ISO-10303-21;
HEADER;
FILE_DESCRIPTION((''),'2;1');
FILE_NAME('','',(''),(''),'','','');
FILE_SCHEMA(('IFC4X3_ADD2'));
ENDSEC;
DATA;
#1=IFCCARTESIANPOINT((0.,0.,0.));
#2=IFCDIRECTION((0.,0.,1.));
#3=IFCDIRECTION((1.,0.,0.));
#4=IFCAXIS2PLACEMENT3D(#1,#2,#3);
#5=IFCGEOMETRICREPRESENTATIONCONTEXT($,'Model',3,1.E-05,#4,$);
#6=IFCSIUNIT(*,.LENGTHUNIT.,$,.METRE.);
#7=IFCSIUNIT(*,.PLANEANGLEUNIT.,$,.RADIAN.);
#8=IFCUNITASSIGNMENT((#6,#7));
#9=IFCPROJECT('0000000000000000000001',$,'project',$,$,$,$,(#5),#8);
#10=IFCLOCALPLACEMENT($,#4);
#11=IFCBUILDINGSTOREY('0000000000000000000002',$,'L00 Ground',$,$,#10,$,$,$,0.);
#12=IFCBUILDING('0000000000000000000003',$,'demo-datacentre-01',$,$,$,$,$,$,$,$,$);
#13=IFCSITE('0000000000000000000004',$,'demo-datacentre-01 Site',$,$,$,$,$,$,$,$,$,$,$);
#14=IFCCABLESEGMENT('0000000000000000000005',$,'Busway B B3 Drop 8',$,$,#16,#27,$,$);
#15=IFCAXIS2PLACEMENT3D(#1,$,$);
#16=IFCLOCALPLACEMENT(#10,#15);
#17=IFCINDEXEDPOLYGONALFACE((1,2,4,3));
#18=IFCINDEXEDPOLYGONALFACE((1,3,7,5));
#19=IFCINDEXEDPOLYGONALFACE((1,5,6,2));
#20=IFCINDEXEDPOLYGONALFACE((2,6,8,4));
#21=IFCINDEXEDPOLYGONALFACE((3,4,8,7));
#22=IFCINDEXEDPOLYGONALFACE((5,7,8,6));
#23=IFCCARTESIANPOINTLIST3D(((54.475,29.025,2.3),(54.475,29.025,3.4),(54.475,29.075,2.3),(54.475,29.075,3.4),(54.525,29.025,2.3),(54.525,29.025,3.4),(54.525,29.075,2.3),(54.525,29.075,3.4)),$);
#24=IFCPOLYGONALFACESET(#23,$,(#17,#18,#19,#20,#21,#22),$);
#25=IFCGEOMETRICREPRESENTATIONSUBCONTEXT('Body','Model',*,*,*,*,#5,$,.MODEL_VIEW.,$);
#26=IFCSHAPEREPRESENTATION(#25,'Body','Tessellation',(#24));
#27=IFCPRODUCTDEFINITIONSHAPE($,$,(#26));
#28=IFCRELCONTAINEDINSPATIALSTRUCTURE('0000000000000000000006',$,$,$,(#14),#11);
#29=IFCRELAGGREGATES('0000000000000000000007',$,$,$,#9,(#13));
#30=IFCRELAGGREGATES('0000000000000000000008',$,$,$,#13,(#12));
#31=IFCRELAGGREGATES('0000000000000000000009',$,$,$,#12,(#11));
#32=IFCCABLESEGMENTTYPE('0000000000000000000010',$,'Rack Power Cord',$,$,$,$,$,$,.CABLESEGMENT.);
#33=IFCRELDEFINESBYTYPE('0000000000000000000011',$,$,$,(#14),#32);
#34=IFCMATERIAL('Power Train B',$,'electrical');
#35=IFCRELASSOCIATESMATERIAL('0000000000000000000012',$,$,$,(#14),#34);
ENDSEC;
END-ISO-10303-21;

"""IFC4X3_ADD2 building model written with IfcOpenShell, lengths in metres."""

from ifc_helpers import new_model, si_unit, frame, origin_with_axes, place, context, subcontext, project, spatial, rectangle, extrude, material, type_object, element, save


model = new_model("IFC4X3_ADD2")

# Units and contexts
model_context = context("Model", 3, precision=1e-05, world=origin_with_axes())
body_context = subcontext(model_context, "Body", "Model", "MODEL_VIEW")
ifc_project = project(units=[si_unit("LENGTHUNIT", "METRE"), si_unit("PLANEANGLEUNIT", "RADIAN")], contexts=[model_context])

# Site, building, storey
site = spatial("IfcSite", under=ifc_project, Name="demo-datacentre-01 Site")
building = spatial("IfcBuilding", under=site, Name="demo-datacentre-01")
storey_placement = place(None, origin_with_axes())
storey = spatial("IfcBuildingStorey", under=building, at=storey_placement, Name="L00 Ground", Elevation=0.0)

# Shared definitions
ifc_material_1 = material(Name="Power Train B", Category="electrical")

# Cable segment
cable_segment_type_1 = type_object("IfcCableSegmentType", Name="Rack Power Cord", PredefinedType="CABLESEGMENT")
for number, where, z_axis, x_axis, name in (
    (1, (54.5, 29.05, 3.4), (0.0, 0.0, -1.0), (1.0, 0.0, 0.0), "Busway B B3 Drop 8"),
):
    element("IfcCableSegment", number, at=place(storey_placement, frame(where, z_axis=z_axis, x_axis=x_axis)), inside=storey, type_object=cable_segment_type_1, material=ifc_material_1, Name=name, context=body_context, shape_type="SweptSolid", body=[
        extrude(rectangle(XDim=0.05, YDim=0.05), origin_with_axes(), (0.0, 0.0, 1.0), 1.1),
    ])

save(model, "model.ifc")
